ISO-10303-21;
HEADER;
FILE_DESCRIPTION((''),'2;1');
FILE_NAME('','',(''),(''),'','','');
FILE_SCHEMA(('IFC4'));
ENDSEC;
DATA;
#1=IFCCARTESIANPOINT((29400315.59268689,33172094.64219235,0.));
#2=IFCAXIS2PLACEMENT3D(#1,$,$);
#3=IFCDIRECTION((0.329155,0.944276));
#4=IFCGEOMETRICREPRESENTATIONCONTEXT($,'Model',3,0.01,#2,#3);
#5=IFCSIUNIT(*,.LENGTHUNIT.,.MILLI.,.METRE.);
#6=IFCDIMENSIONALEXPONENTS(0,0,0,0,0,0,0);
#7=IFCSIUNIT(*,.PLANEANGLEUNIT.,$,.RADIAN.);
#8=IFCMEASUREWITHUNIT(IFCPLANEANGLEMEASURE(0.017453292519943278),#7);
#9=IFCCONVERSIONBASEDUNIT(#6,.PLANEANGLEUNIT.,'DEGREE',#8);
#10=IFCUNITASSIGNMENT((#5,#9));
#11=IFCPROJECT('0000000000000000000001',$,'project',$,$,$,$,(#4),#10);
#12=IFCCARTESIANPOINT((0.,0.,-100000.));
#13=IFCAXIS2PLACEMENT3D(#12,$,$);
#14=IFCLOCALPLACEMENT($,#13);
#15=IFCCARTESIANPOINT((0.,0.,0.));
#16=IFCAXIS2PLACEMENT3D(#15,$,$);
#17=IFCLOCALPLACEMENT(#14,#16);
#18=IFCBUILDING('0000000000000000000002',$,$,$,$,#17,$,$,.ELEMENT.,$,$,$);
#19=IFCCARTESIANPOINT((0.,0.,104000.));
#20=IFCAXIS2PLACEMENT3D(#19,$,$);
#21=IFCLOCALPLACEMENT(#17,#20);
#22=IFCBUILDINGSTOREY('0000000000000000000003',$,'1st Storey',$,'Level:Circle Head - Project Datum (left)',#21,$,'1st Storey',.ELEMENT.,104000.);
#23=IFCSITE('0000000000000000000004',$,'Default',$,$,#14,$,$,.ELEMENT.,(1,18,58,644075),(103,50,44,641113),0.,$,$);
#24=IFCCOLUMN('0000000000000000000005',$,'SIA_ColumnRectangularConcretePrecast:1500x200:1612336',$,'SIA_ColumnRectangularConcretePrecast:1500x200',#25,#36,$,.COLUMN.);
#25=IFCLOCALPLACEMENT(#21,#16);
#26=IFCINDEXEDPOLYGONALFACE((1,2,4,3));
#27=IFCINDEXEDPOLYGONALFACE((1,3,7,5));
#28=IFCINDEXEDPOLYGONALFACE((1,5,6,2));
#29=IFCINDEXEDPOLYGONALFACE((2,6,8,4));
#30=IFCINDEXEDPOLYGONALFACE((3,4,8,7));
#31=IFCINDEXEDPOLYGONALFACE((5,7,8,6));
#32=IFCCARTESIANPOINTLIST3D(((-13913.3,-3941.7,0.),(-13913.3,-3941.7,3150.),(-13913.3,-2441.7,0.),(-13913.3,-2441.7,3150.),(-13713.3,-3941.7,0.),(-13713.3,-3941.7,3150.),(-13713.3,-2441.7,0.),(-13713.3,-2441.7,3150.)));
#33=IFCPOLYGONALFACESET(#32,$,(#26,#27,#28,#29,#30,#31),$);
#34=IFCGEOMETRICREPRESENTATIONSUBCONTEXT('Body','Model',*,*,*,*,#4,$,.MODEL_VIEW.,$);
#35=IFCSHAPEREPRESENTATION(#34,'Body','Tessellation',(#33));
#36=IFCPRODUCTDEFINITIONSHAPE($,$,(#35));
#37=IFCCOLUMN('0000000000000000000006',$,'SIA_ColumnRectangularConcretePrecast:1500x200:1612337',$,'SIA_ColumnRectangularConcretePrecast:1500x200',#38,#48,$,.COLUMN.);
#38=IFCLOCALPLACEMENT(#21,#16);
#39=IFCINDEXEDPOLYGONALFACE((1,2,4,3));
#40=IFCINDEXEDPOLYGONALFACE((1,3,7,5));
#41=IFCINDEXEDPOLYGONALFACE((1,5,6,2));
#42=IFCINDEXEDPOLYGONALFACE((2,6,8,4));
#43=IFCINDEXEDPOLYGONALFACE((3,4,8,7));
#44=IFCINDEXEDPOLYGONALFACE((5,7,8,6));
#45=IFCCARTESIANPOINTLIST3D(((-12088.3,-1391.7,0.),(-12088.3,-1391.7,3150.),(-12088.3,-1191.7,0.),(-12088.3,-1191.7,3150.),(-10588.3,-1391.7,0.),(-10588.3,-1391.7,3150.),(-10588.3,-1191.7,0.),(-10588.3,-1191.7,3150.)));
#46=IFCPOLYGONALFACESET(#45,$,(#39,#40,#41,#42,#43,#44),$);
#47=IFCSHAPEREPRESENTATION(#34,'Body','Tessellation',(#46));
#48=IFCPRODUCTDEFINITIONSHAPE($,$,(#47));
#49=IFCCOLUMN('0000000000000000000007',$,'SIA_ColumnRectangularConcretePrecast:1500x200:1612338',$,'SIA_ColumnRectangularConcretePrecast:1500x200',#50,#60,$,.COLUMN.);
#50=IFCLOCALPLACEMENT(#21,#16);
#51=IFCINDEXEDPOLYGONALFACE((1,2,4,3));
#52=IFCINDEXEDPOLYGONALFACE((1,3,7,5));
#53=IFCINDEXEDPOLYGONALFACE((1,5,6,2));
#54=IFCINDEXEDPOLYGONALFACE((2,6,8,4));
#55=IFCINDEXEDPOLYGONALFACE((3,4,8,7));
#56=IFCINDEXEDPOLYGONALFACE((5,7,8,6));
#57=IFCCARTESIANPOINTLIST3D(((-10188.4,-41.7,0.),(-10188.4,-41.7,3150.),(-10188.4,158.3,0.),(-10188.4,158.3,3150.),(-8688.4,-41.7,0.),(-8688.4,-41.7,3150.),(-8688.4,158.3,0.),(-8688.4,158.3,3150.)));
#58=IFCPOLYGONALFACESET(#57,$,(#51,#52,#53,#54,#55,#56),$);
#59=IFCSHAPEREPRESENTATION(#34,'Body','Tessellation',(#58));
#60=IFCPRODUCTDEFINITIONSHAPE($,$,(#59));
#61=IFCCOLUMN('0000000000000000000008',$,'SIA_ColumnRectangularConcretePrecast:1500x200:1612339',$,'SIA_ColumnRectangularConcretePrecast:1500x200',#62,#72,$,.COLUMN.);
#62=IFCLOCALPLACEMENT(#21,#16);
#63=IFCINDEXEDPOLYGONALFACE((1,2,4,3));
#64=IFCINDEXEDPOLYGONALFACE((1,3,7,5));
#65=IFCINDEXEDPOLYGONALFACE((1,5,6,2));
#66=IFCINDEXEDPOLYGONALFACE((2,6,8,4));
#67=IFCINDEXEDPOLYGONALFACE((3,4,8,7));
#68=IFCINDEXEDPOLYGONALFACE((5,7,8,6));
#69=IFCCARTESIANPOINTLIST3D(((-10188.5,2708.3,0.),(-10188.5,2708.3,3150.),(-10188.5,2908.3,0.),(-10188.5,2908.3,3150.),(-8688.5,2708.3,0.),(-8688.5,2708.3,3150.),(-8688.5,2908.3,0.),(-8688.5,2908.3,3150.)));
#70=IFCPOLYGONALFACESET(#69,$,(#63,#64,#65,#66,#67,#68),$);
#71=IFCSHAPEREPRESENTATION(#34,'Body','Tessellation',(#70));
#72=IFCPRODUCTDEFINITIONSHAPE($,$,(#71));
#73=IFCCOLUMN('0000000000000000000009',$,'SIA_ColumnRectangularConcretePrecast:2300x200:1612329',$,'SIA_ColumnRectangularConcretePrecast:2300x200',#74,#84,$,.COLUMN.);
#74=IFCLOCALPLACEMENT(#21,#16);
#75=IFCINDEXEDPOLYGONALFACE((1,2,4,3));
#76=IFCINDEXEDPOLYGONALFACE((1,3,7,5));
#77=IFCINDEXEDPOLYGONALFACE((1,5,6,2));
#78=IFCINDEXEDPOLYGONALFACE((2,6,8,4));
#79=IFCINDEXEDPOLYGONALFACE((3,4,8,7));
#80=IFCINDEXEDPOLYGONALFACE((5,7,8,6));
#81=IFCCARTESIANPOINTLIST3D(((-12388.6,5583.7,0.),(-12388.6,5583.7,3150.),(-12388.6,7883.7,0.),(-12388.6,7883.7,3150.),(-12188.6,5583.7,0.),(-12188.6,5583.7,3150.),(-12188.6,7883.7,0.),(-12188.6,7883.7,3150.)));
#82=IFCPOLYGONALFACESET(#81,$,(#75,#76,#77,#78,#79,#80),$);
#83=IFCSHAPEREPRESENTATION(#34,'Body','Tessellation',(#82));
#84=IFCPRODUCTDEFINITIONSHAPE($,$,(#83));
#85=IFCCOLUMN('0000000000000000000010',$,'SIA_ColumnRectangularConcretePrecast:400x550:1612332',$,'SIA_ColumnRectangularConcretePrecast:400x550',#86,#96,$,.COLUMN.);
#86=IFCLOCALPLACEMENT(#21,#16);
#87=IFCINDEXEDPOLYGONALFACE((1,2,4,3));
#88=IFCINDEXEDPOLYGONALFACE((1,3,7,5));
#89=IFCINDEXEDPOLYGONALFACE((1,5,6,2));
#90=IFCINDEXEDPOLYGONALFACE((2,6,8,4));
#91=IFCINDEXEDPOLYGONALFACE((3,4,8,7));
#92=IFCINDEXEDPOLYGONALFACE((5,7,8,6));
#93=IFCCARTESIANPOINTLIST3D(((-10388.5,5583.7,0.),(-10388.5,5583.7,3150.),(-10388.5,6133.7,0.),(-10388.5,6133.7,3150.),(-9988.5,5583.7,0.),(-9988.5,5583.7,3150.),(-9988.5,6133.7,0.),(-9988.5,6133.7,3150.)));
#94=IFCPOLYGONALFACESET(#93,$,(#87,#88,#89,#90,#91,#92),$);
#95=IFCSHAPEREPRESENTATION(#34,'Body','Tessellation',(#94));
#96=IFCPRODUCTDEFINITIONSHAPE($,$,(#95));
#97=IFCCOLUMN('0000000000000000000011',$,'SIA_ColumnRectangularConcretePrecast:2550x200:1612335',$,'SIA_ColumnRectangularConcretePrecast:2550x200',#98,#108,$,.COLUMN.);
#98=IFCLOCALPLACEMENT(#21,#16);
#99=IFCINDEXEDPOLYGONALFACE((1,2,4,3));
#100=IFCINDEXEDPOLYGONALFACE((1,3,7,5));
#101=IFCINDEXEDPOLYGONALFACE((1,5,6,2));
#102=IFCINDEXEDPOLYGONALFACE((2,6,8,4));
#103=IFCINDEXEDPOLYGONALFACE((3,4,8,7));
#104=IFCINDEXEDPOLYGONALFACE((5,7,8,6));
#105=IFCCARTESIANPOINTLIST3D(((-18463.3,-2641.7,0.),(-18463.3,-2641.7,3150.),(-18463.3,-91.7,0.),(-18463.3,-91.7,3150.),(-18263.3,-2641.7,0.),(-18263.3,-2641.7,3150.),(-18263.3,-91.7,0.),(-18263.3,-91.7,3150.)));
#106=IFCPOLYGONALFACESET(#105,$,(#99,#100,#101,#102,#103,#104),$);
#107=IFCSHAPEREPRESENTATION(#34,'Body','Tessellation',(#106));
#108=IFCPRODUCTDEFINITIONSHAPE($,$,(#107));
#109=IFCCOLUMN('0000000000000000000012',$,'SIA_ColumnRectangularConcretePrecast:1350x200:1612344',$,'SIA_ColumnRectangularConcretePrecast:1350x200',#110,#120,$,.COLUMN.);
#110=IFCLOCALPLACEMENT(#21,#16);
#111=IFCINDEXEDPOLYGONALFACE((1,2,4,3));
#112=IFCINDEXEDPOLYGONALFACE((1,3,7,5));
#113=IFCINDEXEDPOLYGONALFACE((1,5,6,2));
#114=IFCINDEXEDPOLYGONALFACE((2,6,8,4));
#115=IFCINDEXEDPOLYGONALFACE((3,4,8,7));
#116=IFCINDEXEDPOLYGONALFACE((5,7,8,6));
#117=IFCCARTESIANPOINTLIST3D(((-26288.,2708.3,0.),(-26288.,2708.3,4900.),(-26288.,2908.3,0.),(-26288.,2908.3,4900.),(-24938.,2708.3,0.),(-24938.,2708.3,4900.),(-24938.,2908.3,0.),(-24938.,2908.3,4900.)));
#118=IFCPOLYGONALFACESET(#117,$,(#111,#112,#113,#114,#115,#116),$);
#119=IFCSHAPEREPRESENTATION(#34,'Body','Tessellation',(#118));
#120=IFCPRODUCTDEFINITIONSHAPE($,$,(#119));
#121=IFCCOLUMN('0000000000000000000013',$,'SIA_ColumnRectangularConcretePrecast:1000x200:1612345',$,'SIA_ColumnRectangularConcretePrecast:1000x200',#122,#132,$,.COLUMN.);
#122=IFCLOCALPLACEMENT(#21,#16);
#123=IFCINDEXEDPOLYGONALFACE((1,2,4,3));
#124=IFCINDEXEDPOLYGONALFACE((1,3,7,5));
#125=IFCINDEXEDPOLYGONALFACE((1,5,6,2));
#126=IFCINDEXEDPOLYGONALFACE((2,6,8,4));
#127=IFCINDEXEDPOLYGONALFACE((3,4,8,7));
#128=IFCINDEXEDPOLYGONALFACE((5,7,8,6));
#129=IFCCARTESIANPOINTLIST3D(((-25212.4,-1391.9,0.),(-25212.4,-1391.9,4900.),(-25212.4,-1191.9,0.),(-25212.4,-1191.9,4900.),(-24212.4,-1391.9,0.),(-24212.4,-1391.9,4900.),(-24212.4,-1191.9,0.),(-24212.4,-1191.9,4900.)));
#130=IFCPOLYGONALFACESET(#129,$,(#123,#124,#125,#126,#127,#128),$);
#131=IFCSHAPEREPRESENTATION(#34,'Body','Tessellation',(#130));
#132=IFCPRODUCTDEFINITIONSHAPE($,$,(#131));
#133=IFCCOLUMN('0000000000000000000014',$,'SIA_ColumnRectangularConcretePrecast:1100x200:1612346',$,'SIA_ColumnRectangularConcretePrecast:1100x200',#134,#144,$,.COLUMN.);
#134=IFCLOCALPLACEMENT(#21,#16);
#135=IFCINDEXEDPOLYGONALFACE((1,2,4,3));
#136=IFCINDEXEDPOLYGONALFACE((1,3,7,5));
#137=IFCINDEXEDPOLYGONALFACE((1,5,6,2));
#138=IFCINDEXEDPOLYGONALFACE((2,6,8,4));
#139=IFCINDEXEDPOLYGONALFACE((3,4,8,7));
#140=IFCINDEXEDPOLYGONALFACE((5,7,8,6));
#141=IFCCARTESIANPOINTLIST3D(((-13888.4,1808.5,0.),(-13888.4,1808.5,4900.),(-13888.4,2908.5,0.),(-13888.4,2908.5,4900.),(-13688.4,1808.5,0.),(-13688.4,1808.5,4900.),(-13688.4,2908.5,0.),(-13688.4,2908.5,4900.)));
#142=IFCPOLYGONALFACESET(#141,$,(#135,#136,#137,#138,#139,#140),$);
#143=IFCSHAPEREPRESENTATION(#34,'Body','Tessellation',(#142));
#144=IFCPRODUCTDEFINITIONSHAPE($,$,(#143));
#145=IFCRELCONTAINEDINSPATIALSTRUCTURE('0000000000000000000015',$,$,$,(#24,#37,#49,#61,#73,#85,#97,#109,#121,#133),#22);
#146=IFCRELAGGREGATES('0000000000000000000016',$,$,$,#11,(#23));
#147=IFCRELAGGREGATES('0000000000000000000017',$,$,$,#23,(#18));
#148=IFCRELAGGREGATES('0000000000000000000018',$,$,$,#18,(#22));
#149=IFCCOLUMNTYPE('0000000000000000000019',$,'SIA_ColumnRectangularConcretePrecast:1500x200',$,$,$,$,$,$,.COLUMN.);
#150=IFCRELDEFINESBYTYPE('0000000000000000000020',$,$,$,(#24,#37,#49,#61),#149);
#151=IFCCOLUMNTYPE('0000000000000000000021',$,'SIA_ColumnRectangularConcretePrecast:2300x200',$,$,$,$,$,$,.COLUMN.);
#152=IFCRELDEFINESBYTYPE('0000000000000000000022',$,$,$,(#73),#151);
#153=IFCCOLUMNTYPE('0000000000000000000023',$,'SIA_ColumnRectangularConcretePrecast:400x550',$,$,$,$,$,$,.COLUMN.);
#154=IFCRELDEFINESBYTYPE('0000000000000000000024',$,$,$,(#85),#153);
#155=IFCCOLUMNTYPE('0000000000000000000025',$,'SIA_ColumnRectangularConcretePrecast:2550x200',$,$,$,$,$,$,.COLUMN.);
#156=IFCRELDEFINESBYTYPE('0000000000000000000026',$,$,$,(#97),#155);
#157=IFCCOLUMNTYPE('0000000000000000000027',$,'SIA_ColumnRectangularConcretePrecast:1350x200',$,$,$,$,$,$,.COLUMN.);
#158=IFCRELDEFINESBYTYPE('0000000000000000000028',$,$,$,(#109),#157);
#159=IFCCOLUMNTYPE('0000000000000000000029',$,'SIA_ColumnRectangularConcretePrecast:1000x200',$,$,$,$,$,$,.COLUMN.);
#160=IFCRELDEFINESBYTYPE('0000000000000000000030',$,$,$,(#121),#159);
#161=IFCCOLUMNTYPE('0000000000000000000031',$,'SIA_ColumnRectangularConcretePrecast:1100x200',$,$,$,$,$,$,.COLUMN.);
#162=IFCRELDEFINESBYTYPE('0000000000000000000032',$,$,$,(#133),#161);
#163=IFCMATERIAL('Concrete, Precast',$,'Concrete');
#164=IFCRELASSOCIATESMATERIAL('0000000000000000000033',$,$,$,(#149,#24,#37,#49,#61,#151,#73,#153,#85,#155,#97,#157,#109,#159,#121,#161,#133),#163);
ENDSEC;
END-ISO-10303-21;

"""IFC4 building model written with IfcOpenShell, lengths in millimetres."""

from ifc_helpers import new_model, entity, si_unit, converted_unit, direction, frame, origin, place, context, subcontext, project, spatial, indexed_curve, outline, extrude, source, transform, mapped, material, type_object, type_shapes, element, save


model = new_model("IFC4")

# Units and contexts
model_context = context("Model", 3, precision=0.01, world=frame((29400315.59268689, 33172094.64219235, 0.0)), true_north=direction((0.329155, 0.944276)))
body_context = subcontext(model_context, "Body", "Model", "MODEL_VIEW")
ifc_project = project(units=[si_unit("LENGTHUNIT", "METRE", prefix="MILLI"), converted_unit("PLANEANGLEUNIT", "DEGREE", entity("IfcPlaneAngleMeasure", 0.017453292519943278), si_unit("PLANEANGLEUNIT", "RADIAN"), dimensions=[0, 0, 0, 0, 0, 0, 0])], contexts=[model_context])

# Site, building, storey
site_placement = place(None, frame((0.0, 0.0, -100000.0)))
site = spatial("IfcSite", under=ifc_project, at=site_placement, Name="Default", CompositionType="ELEMENT", RefLatitude=(1, 18, 58, 644075), RefLongitude=(103, 50, 44, 641113), RefElevation=0.0)
building_placement = place(site_placement, origin())
building = spatial("IfcBuilding", under=site, at=building_placement, CompositionType="ELEMENT")
storey_placement = place(building_placement, frame((0.0, 0.0, 104000.0)))
storey = spatial("IfcBuildingStorey", under=building, at=storey_placement, Name="1st Storey", ObjectType="Level:Circle Head - Project Datum (left)", LongName="1st Storey", CompositionType="ELEMENT", Elevation=104000.0)

# Columns
ifc_material = material(Name="Concrete, Precast", Category="Concrete")
column_type_1 = type_object("IfcColumnType", Name="SIA_ColumnRectangularConcretePrecast:1500x200", PredefinedType="COLUMN", material=ifc_material)
shared_shape_1 = source(origin(), body_context, "Body", "SweptSolid", [
    extrude(outline(indexed_curve([(-100.0, -750.0), (100.0, -750.0), (100.0, 750.0), (-100.0, 750.0), (-100.0, -750.0)], self_intersect=False)), frame((0.0, 0.0, 104000.0), z_axis=(0.0, 0.0, 1.0), x_axis=(-1.0, 0.0, 0.0)), (0.0, 0.0, 1.0), 3150.0),
])
type_shapes(column_type_1, [shared_shape_1])
column_1_placement = place(storey_placement, frame((-13813.3, -3191.7, -104000.0)))
element("IfcColumn", 1, at=column_1_placement, inside=storey, type_object=column_type_1, material=ifc_material, Name="SIA_ColumnRectangularConcretePrecast:1500x200:1612336", ObjectType="SIA_ColumnRectangularConcretePrecast:1500x200", PredefinedType="COLUMN", context=body_context, shape_type="MappedRepresentation", body=[
    mapped(shared_shape_1, transform((0.0, 0.0, 0.0), scale=1.0)),
])
for number, where, z_axis, x_axis, name in (
    (2, (-11338.3, -1291.7, -104000.0), (0.0, 0.0, 1.0), (0.0, -1.0, 0.0), "SIA_ColumnRectangularConcretePrecast:1500x200:1612337"),
    (3, (-9438.4, 58.3, -104000.0), (0.0, 0.0, 1.0), (0.0, -1.0, 0.0), "SIA_ColumnRectangularConcretePrecast:1500x200:1612338"),
    (4, (-9438.5, 2808.3, -104000.0), (0.0, 0.0, 1.0), (0.0, -1.0, 0.0), "SIA_ColumnRectangularConcretePrecast:1500x200:1612339"),
):
    element("IfcColumn", number, at=place(storey_placement, frame(where, z_axis=z_axis, x_axis=x_axis)), inside=storey, type_object=column_type_1, material=ifc_material, Name=name, ObjectType="SIA_ColumnRectangularConcretePrecast:1500x200", PredefinedType="COLUMN", context=body_context, shape_type="MappedRepresentation", body=[
        mapped(shared_shape_1, transform((0.0, 0.0, 0.0), scale=1.0)),
    ])
column_type_2 = type_object("IfcColumnType", Name="SIA_ColumnRectangularConcretePrecast:2300x200", PredefinedType="COLUMN", material=ifc_material)
shared_shape_2 = source(origin(), body_context, "Body", "SweptSolid", [
    extrude(outline(indexed_curve([(-100.0, -1150.0), (100.0, -1150.0), (100.0, 1150.0), (-100.0, 1150.0), (-100.0, -1150.0)], self_intersect=False)), frame((0.0, 0.0, 104000.0), z_axis=(0.0, 0.0, 1.0), x_axis=(-1.0, 0.0, 0.0)), (0.0, 0.0, 1.0), 3150.0),
])
type_shapes(column_type_2, [shared_shape_2])
column_2_placement = place(storey_placement, frame((-12288.6, 6733.7, -104000.0)))
element("IfcColumn", 5, at=column_2_placement, inside=storey, type_object=column_type_2, material=ifc_material, Name="SIA_ColumnRectangularConcretePrecast:2300x200:1612329", ObjectType="SIA_ColumnRectangularConcretePrecast:2300x200", PredefinedType="COLUMN", context=body_context, shape_type="MappedRepresentation", body=[
    mapped(shared_shape_2, transform((0.0, 0.0, 0.0), scale=1.0)),
])
column_type_3 = type_object("IfcColumnType", Name="SIA_ColumnRectangularConcretePrecast:400x550", PredefinedType="COLUMN", material=ifc_material)
shared_shape_3 = source(origin(), body_context, "Body", "SweptSolid", [
    extrude(outline(indexed_curve([(-275.0, -200.0), (275.0, -200.0), (275.0, 200.0), (-275.0, 200.0), (-275.0, -200.0)], self_intersect=False)), frame((0.0, 0.0, 104000.0), z_axis=(0.0, 0.0, 1.0), x_axis=(-1.0, 0.0, 0.0)), (0.0, 0.0, 1.0), 3150.0),
])
type_shapes(column_type_3, [shared_shape_3])
column_3_placement = place(storey_placement, frame((-10188.5, 5858.7, -104000.0), z_axis=(0.0, 0.0, 1.0), x_axis=(0.0, -1.0, 0.0)))
element("IfcColumn", 6, at=column_3_placement, inside=storey, type_object=column_type_3, material=ifc_material, Name="SIA_ColumnRectangularConcretePrecast:400x550:1612332", ObjectType="SIA_ColumnRectangularConcretePrecast:400x550", PredefinedType="COLUMN", context=body_context, shape_type="MappedRepresentation", body=[
    mapped(shared_shape_3, transform((0.0, 0.0, 0.0), scale=1.0)),
])
column_type_4 = type_object("IfcColumnType", Name="SIA_ColumnRectangularConcretePrecast:2550x200", PredefinedType="COLUMN", material=ifc_material)
shared_shape_4 = source(origin(), body_context, "Body", "SweptSolid", [
    extrude(outline(indexed_curve([(-100.0, -1275.0), (100.0, -1275.0), (100.0, 1275.0), (-100.0, 1275.0), (-100.0, -1275.0)], self_intersect=False)), frame((0.0, 0.0, 104000.0), z_axis=(0.0, 0.0, 1.0), x_axis=(-1.0, 0.0, 0.0)), (0.0, 0.0, 1.0), 3150.0),
])
type_shapes(column_type_4, [shared_shape_4])
column_4_placement = place(storey_placement, frame((-18363.3, -1366.7, -104000.0)))
element("IfcColumn", 7, at=column_4_placement, inside=storey, type_object=column_type_4, material=ifc_material, Name="SIA_ColumnRectangularConcretePrecast:2550x200:1612335", ObjectType="SIA_ColumnRectangularConcretePrecast:2550x200", PredefinedType="COLUMN", context=body_context, shape_type="MappedRepresentation", body=[
    mapped(shared_shape_4, transform((0.0, 0.0, 0.0), scale=1.0)),
])
column_type_5 = type_object("IfcColumnType", Name="SIA_ColumnRectangularConcretePrecast:1350x200", PredefinedType="COLUMN", material=ifc_material)
shared_shape_5 = source(origin(), body_context, "Body", "SweptSolid", [
    extrude(outline(indexed_curve([(-100.0, -675.0), (100.0, -675.0), (100.0, 675.0), (-100.0, 675.0), (-100.0, -675.0)], self_intersect=False)), frame((0.0, 0.0, 104000.0), z_axis=(0.0, 0.0, 1.0), x_axis=(-1.0, 0.0, 0.0)), (0.0, 0.0, 1.0), 4900.0),
])
type_shapes(column_type_5, [shared_shape_5])
column_5_placement = place(storey_placement, frame((-25613.0, 2808.3, -104000.0), z_axis=(0.0, 0.0, 1.0), x_axis=(0.0, -1.0, 0.0)))
element("IfcColumn", 8, at=column_5_placement, inside=storey, type_object=column_type_5, material=ifc_material, Name="SIA_ColumnRectangularConcretePrecast:1350x200:1612344", ObjectType="SIA_ColumnRectangularConcretePrecast:1350x200", PredefinedType="COLUMN", context=body_context, shape_type="MappedRepresentation", body=[
    mapped(shared_shape_5, transform((0.0, 0.0, 0.0), scale=1.0)),
])
column_type_6 = type_object("IfcColumnType", Name="SIA_ColumnRectangularConcretePrecast:1000x200", PredefinedType="COLUMN", material=ifc_material)
shared_shape_6 = source(origin(), body_context, "Body", "SweptSolid", [
    extrude(outline(indexed_curve([(-100.0, -500.0), (100.0, -500.0), (100.0, 500.0), (-100.0, 500.0), (-100.0, -500.0)], self_intersect=False)), frame((0.0, 0.0, 104000.0), z_axis=(0.0, 0.0, 1.0), x_axis=(-1.0, 0.0, 0.0)), (0.0, 0.0, 1.0), 4900.0),
])
type_shapes(column_type_6, [shared_shape_6])
column_6_placement = place(storey_placement, frame((-24712.4, -1291.9, -104000.0), z_axis=(0.0, 0.0, 1.0), x_axis=(0.0, -1.0, 0.0)))
element("IfcColumn", 9, at=column_6_placement, inside=storey, type_object=column_type_6, material=ifc_material, Name="SIA_ColumnRectangularConcretePrecast:1000x200:1612345", ObjectType="SIA_ColumnRectangularConcretePrecast:1000x200", PredefinedType="COLUMN", context=body_context, shape_type="MappedRepresentation", body=[
    mapped(shared_shape_6, transform((0.0, 0.0, 0.0), scale=1.0)),
])
column_type_7 = type_object("IfcColumnType", Name="SIA_ColumnRectangularConcretePrecast:1100x200", PredefinedType="COLUMN", material=ifc_material)
shared_shape_7 = source(origin(), body_context, "Body", "SweptSolid", [
    extrude(outline(indexed_curve([(-100.0, -550.0), (100.0, -550.0), (100.0, 550.0), (-100.0, 550.0), (-100.0, -550.0)], self_intersect=False)), frame((0.0, 0.0, 104000.0), z_axis=(0.0, 0.0, 1.0), x_axis=(-1.0, 0.0, 0.0)), (0.0, 0.0, 1.0), 4900.0),
])
type_shapes(column_type_7, [shared_shape_7])
column_7_placement = place(storey_placement, frame((-13788.4, 2358.5, -104000.0)))
element("IfcColumn", 10, at=column_7_placement, inside=storey, type_object=column_type_7, material=ifc_material, Name="SIA_ColumnRectangularConcretePrecast:1100x200:1612346", ObjectType="SIA_ColumnRectangularConcretePrecast:1100x200", PredefinedType="COLUMN", context=body_context, shape_type="MappedRepresentation", body=[
    mapped(shared_shape_7, transform((0.0, 0.0, 0.0), scale=1.0)),
])

save(model, "model.ifc")
